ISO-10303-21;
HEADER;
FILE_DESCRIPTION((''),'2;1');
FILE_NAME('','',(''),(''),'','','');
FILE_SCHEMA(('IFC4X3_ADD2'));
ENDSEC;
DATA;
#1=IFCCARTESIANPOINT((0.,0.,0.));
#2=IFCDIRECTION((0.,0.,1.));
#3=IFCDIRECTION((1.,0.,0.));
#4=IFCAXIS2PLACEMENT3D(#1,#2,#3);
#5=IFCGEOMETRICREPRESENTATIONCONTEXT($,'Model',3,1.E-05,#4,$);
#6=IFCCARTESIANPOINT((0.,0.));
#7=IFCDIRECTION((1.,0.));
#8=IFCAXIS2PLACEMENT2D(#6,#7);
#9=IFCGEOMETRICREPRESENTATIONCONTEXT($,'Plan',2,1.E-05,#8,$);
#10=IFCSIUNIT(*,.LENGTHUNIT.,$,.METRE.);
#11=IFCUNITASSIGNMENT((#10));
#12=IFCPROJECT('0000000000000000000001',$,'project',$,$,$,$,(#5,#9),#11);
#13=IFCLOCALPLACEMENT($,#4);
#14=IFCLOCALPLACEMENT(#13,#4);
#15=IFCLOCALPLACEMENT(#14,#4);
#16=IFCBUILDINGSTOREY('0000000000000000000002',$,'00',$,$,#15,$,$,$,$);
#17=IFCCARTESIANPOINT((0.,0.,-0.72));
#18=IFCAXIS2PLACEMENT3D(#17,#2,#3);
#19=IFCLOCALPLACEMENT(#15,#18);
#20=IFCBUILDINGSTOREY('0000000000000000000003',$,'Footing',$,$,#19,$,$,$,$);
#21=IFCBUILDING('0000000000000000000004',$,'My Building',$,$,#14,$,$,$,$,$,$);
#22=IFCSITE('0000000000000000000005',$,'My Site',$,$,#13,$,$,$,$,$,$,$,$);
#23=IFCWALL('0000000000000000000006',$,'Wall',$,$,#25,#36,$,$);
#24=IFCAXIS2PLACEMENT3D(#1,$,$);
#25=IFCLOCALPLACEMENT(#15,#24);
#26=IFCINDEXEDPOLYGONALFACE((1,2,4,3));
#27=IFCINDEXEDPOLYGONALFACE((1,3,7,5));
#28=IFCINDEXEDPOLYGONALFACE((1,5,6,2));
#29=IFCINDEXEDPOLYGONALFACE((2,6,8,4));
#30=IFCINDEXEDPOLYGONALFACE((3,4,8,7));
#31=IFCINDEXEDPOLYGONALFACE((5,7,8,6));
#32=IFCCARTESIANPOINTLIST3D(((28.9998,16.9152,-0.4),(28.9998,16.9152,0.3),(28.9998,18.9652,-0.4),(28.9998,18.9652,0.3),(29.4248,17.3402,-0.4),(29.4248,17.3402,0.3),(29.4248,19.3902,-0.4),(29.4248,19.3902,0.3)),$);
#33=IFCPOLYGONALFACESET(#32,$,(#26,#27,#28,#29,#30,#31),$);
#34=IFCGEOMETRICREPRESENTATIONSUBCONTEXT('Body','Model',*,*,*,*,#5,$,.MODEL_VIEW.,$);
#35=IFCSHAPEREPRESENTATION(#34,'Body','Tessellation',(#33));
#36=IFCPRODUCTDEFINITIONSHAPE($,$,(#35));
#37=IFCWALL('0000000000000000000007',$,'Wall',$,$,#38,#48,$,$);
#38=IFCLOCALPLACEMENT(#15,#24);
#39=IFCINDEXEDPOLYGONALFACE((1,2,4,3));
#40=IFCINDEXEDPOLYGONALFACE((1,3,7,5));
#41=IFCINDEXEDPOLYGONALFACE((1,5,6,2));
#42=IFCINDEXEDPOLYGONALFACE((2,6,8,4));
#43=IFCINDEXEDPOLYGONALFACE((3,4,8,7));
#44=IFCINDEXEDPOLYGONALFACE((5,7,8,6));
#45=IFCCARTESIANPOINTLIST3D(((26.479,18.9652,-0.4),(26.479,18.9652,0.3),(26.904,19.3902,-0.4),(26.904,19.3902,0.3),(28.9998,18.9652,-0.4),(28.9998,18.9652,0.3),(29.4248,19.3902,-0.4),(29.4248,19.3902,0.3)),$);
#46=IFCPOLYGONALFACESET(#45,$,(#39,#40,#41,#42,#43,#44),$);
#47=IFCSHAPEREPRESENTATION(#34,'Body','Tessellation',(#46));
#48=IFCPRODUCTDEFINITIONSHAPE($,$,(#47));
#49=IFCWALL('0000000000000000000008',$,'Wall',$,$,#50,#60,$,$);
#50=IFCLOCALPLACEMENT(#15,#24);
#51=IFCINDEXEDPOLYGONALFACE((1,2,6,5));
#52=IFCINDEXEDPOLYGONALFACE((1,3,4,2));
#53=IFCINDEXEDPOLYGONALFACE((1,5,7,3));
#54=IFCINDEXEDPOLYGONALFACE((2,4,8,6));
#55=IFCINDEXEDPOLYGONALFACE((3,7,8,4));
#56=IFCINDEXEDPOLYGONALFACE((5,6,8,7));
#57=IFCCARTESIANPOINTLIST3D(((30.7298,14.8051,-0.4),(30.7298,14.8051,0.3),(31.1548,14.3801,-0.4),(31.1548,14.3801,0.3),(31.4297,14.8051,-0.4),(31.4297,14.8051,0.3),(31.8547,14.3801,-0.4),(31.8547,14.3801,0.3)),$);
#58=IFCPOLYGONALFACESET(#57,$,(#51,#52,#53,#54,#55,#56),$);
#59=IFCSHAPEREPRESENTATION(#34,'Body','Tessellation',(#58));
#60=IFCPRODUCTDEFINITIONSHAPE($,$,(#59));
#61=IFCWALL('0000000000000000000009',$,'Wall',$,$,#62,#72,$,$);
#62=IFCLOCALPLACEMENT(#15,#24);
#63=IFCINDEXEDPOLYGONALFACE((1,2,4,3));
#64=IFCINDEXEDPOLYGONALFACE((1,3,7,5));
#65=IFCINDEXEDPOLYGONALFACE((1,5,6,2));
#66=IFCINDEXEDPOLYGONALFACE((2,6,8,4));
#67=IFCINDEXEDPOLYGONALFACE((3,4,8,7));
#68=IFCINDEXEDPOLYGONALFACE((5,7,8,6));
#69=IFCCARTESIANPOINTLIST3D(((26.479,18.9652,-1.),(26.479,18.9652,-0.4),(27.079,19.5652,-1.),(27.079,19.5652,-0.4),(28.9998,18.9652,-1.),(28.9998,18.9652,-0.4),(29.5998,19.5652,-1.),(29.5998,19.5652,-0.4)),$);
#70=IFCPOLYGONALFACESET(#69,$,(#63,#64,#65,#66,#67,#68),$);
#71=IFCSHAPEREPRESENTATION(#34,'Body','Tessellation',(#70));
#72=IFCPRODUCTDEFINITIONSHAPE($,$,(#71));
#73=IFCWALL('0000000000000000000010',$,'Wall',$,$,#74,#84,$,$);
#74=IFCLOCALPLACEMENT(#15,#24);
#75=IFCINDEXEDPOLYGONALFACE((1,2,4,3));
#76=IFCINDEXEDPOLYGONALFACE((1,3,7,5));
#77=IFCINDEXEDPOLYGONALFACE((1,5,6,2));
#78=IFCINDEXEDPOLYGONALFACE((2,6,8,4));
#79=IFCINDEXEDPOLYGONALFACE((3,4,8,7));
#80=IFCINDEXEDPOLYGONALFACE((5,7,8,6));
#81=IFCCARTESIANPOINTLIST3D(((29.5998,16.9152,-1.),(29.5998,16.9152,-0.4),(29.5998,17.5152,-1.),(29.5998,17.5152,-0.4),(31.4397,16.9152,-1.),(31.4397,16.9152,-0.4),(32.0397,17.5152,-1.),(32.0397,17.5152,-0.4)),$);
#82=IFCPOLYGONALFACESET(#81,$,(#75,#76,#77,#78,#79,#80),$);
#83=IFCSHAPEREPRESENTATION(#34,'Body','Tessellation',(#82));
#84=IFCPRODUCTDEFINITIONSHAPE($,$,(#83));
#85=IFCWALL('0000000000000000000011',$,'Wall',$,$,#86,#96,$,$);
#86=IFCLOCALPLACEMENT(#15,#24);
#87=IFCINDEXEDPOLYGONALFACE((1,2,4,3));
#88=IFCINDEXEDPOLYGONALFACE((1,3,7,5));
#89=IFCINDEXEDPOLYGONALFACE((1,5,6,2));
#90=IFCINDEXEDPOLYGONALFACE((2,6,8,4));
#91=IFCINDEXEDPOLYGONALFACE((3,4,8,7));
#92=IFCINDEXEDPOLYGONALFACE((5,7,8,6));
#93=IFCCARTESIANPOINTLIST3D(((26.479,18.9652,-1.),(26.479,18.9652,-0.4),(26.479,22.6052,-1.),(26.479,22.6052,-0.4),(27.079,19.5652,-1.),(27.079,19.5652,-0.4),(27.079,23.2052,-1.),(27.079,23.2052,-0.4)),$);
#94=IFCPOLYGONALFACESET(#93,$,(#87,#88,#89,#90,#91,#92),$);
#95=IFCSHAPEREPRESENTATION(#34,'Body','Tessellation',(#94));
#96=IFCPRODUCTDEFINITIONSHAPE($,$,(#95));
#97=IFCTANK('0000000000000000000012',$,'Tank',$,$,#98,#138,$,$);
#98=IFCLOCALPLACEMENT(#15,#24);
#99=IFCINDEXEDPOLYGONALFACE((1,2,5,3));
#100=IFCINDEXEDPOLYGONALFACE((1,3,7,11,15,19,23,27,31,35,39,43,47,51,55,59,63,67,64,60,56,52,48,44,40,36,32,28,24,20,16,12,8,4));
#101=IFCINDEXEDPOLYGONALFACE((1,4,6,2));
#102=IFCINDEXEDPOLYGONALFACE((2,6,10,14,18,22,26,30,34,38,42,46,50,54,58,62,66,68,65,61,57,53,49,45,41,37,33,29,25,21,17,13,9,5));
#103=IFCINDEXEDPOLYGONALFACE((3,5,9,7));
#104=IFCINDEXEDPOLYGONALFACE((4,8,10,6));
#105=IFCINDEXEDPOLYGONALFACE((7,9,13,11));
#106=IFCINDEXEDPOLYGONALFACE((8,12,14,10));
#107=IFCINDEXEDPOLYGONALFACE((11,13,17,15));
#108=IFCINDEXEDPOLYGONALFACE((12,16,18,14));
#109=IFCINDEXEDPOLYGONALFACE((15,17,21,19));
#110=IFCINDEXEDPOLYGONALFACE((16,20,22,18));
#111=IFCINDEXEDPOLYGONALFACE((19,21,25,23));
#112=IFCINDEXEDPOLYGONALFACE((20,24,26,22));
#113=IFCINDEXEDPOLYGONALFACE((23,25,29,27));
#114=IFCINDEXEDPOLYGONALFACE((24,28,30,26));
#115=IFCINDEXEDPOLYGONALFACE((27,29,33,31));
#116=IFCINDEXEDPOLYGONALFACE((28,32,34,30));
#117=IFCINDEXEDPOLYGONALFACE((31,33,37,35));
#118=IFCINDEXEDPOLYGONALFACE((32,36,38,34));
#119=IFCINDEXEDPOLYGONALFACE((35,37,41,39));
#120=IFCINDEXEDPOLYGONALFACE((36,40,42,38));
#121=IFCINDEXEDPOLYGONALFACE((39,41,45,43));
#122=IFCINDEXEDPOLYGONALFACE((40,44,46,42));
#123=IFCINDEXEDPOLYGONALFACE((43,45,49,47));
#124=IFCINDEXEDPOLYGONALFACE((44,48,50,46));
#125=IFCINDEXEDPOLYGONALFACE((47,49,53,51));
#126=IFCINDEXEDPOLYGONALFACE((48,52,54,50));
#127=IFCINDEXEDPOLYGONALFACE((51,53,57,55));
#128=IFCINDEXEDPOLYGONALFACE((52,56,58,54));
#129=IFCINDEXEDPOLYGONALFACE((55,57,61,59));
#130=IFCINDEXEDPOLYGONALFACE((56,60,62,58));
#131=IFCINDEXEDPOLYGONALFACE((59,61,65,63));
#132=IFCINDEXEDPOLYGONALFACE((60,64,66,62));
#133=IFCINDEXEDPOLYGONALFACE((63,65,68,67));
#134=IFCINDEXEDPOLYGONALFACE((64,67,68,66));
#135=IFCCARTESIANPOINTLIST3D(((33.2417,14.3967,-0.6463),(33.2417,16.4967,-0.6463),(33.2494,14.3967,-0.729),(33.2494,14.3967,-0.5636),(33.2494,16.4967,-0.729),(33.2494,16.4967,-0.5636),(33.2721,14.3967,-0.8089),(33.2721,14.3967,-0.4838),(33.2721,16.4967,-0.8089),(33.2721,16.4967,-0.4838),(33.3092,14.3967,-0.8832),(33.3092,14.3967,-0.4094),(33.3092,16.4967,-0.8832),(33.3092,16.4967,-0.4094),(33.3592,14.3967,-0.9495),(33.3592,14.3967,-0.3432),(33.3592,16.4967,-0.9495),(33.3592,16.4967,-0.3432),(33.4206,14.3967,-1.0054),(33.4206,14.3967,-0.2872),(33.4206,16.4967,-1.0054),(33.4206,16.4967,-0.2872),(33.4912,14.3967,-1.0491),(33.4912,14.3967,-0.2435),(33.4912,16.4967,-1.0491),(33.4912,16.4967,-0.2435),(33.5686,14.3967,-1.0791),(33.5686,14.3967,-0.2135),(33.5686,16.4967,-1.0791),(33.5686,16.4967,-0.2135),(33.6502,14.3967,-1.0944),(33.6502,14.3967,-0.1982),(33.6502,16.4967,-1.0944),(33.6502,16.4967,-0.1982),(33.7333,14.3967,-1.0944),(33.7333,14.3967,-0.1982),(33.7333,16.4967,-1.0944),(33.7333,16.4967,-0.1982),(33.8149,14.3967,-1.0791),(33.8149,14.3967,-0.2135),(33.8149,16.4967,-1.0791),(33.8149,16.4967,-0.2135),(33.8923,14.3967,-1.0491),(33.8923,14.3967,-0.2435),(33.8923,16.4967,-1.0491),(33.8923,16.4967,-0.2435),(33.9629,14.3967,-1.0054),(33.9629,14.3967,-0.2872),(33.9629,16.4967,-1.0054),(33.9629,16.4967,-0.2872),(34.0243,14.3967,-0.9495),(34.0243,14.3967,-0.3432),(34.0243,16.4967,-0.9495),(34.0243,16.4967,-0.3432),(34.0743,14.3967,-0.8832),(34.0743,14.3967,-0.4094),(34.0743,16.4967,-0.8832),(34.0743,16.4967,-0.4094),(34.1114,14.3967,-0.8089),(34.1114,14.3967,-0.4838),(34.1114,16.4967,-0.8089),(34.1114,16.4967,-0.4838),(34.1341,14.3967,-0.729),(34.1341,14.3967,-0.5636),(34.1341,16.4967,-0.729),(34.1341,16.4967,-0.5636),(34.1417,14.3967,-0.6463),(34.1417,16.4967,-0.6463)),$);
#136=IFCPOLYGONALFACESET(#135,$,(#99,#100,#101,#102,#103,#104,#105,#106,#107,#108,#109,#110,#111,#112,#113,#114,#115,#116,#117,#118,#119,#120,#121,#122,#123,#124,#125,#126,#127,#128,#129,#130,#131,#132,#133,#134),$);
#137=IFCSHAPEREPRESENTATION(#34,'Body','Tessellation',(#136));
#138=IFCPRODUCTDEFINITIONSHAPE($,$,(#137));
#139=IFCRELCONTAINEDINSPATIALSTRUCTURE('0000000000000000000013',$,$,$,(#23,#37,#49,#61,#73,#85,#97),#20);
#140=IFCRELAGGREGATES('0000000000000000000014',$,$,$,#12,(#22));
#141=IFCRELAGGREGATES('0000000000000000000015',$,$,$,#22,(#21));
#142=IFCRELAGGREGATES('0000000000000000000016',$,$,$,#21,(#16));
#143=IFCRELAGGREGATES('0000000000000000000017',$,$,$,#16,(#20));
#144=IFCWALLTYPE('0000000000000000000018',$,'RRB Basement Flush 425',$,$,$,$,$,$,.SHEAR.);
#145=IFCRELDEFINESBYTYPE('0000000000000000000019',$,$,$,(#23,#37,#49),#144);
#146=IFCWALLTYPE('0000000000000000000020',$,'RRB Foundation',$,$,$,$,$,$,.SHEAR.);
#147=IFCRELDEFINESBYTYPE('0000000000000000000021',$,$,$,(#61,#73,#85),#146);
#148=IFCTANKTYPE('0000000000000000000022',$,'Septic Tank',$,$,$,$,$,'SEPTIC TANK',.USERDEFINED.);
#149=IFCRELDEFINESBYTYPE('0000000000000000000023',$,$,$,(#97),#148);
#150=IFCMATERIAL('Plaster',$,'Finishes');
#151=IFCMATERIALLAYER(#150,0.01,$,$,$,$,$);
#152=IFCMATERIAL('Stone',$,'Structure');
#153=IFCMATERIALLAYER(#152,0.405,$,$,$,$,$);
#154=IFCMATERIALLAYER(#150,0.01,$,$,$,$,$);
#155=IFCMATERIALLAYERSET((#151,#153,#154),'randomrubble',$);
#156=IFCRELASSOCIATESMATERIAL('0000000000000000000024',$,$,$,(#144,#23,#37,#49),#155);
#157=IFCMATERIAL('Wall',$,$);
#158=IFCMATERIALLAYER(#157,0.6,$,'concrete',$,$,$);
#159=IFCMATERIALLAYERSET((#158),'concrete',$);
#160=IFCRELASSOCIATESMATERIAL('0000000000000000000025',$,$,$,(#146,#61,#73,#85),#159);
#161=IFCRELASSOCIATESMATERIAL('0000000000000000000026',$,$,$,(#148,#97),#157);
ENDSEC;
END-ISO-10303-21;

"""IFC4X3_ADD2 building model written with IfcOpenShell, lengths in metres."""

from ifc_helpers import new_model, si_unit, frame, origin_with_axes, origin_2d_with_axis, place, context, subcontext, project, spatial, line, indexed_curve, circle, outline, extrude, material, layer, layer_set, layer_usage, material_profile, profile_set, profile_usage, type_object, element, save


model = new_model("IFC4X3_ADD2")

# Units and contexts
model_context = context("Model", 3, precision=1e-05, world=origin_with_axes())
plan_context = context("Plan", 2, precision=1e-05, world=origin_2d_with_axis())
body_context = subcontext(model_context, "Body", "Model", "MODEL_VIEW")
ifc_project = project(units=[si_unit("LENGTHUNIT", "METRE")], contexts=[model_context, plan_context])

# Site, building, storeys
site_placement = place(None, origin_with_axes())
site = spatial("IfcSite", under=ifc_project, at=site_placement, Name="My Site")
building_placement = place(site_placement, origin_with_axes())
building = spatial("IfcBuilding", under=site, at=building_placement, Name="My Building")
storey_1_placement = place(building_placement, origin_with_axes())
storey_1 = spatial("IfcBuildingStorey", under=building, at=storey_1_placement, Name="00")
storey_2_placement = place(storey_1_placement, frame((0.0, 0.0, -0.72), z_axis=(0.0, 0.0, 1.0), x_axis=(1.0, 0.0, 0.0)))
storey_2 = spatial("IfcBuildingStorey", under=storey_1, at=storey_2_placement, Name="Footing")

# Shared definitions
ifc_material_1 = material(Name="Plaster", Category="Finishes")
ifc_material_2 = material(Name="Stone", Category="Structure")
ifc_material_3 = material(Name="Wall")

# Walls
ifc_layer_1 = layer(ifc_material_1, 0.01)
ifc_layer_2 = layer(ifc_material_2, 0.405)
ifc_layer_3 = layer(ifc_material_1, 0.01)
ifc_layer_set_1 = layer_set([ifc_layer_1, ifc_layer_2, ifc_layer_3], Name="randomrubble")
wall_type_1 = type_object("IfcWallType", Name="RRB Basement Flush 425", PredefinedType="SHEAR", material=ifc_layer_set_1)
ifc_layer_usage_1 = layer_usage(ifc_layer_set_1, "AXIS2", "POSITIVE", 0.0)
wall_1_placement = place(storey_2_placement, frame((29.4248, 16.9152, 0.32), z_axis=(0.0, 0.0, 1.0), x_axis=(0.0, 1.0, 0.0)))
element("IfcWall", 1, at=wall_1_placement, inside=storey_2, type_object=wall_type_1, material=ifc_layer_usage_1, Name="Wall", context=body_context, shape_type="SweptSolid", body=[
    extrude(outline(indexed_curve([(0.425, 0.0), (0.0, 0.425), (2.05, 0.425), (2.475, 0.0)], segments=[line(1, 2, 3, 4, 1)])), origin_with_axes(), (0.0, 0.0, 1.0), 0.7),
])
ifc_layer_usage_2 = layer_usage(ifc_layer_set_1, "AXIS2", "POSITIVE", 0.0)
wall_2_placement = place(storey_2_placement, frame((26.904, 18.9652, 0.32), z_axis=(0.0, 0.0, 1.0), x_axis=(1.0, 0.0, 0.0)))
element("IfcWall", 2, at=wall_2_placement, inside=storey_2, type_object=wall_type_1, material=ifc_layer_usage_2, Name="Wall", context=body_context, shape_type="SweptSolid", body=[
    extrude(outline(indexed_curve([(-0.425, 0.0), (0.0, 0.425), (2.5208, 0.425), (2.0958, 0.0)], segments=[line(1, 2, 3, 4, 1)])), origin_with_axes(), (0.0, 0.0, 1.0), 0.7),
])
ifc_layer_usage_3 = layer_usage(ifc_layer_set_1, "AXIS2", "POSITIVE", 0.0)
wall_3_placement = place(storey_2_placement, frame((31.1548, 14.3801, 0.32), z_axis=(0.0, 0.0, 1.0), x_axis=(1.0, 0.0, 0.0)))
element("IfcWall", 3, at=wall_3_placement, inside=storey_2, type_object=wall_type_1, material=ifc_layer_usage_3, Name="Wall", context=body_context, shape_type="SweptSolid", body=[
    extrude(outline(indexed_curve([(0.0, 0.0), (-0.425, 0.425), (0.275, 0.425), (0.7, 0.0)], segments=[line(1, 2, 3, 4, 1)])), origin_with_axes(), (0.0, 0.0, 1.0), 0.7),
])
ifc_layer_4 = layer(ifc_material_3, 0.6, Name="concrete")
ifc_layer_set_2 = layer_set([ifc_layer_4], Name="concrete")
ifc_layer_usage_4 = layer_usage(ifc_layer_set_2, "AXIS2", "POSITIVE", 0.0)
wall_type_2 = type_object("IfcWallType", Name="RRB Foundation", PredefinedType="SHEAR", material=ifc_layer_set_2)
wall_4_placement = place(storey_2_placement, frame((27.079, 18.9652, -0.28), z_axis=(0.0, 0.0, 1.0), x_axis=(1.0, 0.0, 0.0)))
element("IfcWall", 4, at=wall_4_placement, inside=storey_2, type_object=wall_type_2, material=ifc_layer_usage_4, Name="Wall", context=body_context, shape_type="SweptSolid", body=[
    extrude(outline(indexed_curve([(-0.6, 0.0), (0.0, 0.6), (2.5208, 0.6), (1.9208, 0.0)], segments=[line(1, 2, 3, 4, 1)])), origin_with_axes(), (0.0, 0.0, 1.0), 0.6),
])
ifc_layer_usage_5 = layer_usage(ifc_layer_set_2, "AXIS2", "POSITIVE", 0.0)
wall_5_placement = place(storey_2_placement, frame((29.5998, 16.9152, -0.28), z_axis=(0.0, 0.0, 1.0), x_axis=(1.0, 0.0, 0.0)))
element("IfcWall", 5, at=wall_5_placement, inside=storey_2, type_object=wall_type_2, material=ifc_layer_usage_5, Name="Wall", context=body_context, shape_type="SweptSolid", body=[
    extrude(outline(indexed_curve([(0.0, 0.0), (0.0, 0.6), (2.44, 0.6), (1.84, 0.0)], segments=[line(1, 2, 3, 4, 1)])), origin_with_axes(), (0.0, 0.0, 1.0), 0.6),
])
ifc_layer_usage_6 = layer_usage(ifc_layer_set_2, "AXIS2", "POSITIVE", 0.0)
wall_6_placement = place(storey_2_placement, frame((27.079, 18.9652, -0.28), z_axis=(0.0, 0.0, 1.0), x_axis=(0.0, 1.0, 0.0)))
element("IfcWall", 6, at=wall_6_placement, inside=storey_2, type_object=wall_type_2, material=ifc_layer_usage_6, Name="Wall", context=body_context, shape_type="SweptSolid", body=[
    extrude(outline(indexed_curve([(0.6, 0.0), (0.0, 0.6), (3.64, 0.6), (4.24, 0.0)], segments=[line(1, 2, 3, 4, 1)])), origin_with_axes(), (0.0, 0.0, 1.0), 0.6),
])

# Tank
ifc_material_profile_1 = material_profile(ifc_material_3, circle(Radius=0.45))
ifc_profile_set_1 = profile_set([ifc_material_profile_1])
ifc_profile_usage_1 = profile_usage(ifc_profile_set_1, cardinal=5)
tank_type = type_object("IfcTankType", Name="Septic Tank", ElementType="SEPTIC TANK", PredefinedType="USERDEFINED", material=ifc_profile_set_1)
tank_placement = place(storey_2_placement, frame((33.6917, 14.3967, 0.0737), z_axis=(0.0, 1.0, 0.0), x_axis=(-1.0, 0.0, 0.0)))
element("IfcTank", 7, at=tank_placement, inside=storey_2, type_object=tank_type, material=ifc_profile_usage_1, Name="Tank", context=body_context, shape_type="SweptSolid", body=[
    extrude(circle(Radius=0.45), origin_with_axes(), (0.0, 0.0, 1.0), 2.1),
])

save(model, "model.ifc")
